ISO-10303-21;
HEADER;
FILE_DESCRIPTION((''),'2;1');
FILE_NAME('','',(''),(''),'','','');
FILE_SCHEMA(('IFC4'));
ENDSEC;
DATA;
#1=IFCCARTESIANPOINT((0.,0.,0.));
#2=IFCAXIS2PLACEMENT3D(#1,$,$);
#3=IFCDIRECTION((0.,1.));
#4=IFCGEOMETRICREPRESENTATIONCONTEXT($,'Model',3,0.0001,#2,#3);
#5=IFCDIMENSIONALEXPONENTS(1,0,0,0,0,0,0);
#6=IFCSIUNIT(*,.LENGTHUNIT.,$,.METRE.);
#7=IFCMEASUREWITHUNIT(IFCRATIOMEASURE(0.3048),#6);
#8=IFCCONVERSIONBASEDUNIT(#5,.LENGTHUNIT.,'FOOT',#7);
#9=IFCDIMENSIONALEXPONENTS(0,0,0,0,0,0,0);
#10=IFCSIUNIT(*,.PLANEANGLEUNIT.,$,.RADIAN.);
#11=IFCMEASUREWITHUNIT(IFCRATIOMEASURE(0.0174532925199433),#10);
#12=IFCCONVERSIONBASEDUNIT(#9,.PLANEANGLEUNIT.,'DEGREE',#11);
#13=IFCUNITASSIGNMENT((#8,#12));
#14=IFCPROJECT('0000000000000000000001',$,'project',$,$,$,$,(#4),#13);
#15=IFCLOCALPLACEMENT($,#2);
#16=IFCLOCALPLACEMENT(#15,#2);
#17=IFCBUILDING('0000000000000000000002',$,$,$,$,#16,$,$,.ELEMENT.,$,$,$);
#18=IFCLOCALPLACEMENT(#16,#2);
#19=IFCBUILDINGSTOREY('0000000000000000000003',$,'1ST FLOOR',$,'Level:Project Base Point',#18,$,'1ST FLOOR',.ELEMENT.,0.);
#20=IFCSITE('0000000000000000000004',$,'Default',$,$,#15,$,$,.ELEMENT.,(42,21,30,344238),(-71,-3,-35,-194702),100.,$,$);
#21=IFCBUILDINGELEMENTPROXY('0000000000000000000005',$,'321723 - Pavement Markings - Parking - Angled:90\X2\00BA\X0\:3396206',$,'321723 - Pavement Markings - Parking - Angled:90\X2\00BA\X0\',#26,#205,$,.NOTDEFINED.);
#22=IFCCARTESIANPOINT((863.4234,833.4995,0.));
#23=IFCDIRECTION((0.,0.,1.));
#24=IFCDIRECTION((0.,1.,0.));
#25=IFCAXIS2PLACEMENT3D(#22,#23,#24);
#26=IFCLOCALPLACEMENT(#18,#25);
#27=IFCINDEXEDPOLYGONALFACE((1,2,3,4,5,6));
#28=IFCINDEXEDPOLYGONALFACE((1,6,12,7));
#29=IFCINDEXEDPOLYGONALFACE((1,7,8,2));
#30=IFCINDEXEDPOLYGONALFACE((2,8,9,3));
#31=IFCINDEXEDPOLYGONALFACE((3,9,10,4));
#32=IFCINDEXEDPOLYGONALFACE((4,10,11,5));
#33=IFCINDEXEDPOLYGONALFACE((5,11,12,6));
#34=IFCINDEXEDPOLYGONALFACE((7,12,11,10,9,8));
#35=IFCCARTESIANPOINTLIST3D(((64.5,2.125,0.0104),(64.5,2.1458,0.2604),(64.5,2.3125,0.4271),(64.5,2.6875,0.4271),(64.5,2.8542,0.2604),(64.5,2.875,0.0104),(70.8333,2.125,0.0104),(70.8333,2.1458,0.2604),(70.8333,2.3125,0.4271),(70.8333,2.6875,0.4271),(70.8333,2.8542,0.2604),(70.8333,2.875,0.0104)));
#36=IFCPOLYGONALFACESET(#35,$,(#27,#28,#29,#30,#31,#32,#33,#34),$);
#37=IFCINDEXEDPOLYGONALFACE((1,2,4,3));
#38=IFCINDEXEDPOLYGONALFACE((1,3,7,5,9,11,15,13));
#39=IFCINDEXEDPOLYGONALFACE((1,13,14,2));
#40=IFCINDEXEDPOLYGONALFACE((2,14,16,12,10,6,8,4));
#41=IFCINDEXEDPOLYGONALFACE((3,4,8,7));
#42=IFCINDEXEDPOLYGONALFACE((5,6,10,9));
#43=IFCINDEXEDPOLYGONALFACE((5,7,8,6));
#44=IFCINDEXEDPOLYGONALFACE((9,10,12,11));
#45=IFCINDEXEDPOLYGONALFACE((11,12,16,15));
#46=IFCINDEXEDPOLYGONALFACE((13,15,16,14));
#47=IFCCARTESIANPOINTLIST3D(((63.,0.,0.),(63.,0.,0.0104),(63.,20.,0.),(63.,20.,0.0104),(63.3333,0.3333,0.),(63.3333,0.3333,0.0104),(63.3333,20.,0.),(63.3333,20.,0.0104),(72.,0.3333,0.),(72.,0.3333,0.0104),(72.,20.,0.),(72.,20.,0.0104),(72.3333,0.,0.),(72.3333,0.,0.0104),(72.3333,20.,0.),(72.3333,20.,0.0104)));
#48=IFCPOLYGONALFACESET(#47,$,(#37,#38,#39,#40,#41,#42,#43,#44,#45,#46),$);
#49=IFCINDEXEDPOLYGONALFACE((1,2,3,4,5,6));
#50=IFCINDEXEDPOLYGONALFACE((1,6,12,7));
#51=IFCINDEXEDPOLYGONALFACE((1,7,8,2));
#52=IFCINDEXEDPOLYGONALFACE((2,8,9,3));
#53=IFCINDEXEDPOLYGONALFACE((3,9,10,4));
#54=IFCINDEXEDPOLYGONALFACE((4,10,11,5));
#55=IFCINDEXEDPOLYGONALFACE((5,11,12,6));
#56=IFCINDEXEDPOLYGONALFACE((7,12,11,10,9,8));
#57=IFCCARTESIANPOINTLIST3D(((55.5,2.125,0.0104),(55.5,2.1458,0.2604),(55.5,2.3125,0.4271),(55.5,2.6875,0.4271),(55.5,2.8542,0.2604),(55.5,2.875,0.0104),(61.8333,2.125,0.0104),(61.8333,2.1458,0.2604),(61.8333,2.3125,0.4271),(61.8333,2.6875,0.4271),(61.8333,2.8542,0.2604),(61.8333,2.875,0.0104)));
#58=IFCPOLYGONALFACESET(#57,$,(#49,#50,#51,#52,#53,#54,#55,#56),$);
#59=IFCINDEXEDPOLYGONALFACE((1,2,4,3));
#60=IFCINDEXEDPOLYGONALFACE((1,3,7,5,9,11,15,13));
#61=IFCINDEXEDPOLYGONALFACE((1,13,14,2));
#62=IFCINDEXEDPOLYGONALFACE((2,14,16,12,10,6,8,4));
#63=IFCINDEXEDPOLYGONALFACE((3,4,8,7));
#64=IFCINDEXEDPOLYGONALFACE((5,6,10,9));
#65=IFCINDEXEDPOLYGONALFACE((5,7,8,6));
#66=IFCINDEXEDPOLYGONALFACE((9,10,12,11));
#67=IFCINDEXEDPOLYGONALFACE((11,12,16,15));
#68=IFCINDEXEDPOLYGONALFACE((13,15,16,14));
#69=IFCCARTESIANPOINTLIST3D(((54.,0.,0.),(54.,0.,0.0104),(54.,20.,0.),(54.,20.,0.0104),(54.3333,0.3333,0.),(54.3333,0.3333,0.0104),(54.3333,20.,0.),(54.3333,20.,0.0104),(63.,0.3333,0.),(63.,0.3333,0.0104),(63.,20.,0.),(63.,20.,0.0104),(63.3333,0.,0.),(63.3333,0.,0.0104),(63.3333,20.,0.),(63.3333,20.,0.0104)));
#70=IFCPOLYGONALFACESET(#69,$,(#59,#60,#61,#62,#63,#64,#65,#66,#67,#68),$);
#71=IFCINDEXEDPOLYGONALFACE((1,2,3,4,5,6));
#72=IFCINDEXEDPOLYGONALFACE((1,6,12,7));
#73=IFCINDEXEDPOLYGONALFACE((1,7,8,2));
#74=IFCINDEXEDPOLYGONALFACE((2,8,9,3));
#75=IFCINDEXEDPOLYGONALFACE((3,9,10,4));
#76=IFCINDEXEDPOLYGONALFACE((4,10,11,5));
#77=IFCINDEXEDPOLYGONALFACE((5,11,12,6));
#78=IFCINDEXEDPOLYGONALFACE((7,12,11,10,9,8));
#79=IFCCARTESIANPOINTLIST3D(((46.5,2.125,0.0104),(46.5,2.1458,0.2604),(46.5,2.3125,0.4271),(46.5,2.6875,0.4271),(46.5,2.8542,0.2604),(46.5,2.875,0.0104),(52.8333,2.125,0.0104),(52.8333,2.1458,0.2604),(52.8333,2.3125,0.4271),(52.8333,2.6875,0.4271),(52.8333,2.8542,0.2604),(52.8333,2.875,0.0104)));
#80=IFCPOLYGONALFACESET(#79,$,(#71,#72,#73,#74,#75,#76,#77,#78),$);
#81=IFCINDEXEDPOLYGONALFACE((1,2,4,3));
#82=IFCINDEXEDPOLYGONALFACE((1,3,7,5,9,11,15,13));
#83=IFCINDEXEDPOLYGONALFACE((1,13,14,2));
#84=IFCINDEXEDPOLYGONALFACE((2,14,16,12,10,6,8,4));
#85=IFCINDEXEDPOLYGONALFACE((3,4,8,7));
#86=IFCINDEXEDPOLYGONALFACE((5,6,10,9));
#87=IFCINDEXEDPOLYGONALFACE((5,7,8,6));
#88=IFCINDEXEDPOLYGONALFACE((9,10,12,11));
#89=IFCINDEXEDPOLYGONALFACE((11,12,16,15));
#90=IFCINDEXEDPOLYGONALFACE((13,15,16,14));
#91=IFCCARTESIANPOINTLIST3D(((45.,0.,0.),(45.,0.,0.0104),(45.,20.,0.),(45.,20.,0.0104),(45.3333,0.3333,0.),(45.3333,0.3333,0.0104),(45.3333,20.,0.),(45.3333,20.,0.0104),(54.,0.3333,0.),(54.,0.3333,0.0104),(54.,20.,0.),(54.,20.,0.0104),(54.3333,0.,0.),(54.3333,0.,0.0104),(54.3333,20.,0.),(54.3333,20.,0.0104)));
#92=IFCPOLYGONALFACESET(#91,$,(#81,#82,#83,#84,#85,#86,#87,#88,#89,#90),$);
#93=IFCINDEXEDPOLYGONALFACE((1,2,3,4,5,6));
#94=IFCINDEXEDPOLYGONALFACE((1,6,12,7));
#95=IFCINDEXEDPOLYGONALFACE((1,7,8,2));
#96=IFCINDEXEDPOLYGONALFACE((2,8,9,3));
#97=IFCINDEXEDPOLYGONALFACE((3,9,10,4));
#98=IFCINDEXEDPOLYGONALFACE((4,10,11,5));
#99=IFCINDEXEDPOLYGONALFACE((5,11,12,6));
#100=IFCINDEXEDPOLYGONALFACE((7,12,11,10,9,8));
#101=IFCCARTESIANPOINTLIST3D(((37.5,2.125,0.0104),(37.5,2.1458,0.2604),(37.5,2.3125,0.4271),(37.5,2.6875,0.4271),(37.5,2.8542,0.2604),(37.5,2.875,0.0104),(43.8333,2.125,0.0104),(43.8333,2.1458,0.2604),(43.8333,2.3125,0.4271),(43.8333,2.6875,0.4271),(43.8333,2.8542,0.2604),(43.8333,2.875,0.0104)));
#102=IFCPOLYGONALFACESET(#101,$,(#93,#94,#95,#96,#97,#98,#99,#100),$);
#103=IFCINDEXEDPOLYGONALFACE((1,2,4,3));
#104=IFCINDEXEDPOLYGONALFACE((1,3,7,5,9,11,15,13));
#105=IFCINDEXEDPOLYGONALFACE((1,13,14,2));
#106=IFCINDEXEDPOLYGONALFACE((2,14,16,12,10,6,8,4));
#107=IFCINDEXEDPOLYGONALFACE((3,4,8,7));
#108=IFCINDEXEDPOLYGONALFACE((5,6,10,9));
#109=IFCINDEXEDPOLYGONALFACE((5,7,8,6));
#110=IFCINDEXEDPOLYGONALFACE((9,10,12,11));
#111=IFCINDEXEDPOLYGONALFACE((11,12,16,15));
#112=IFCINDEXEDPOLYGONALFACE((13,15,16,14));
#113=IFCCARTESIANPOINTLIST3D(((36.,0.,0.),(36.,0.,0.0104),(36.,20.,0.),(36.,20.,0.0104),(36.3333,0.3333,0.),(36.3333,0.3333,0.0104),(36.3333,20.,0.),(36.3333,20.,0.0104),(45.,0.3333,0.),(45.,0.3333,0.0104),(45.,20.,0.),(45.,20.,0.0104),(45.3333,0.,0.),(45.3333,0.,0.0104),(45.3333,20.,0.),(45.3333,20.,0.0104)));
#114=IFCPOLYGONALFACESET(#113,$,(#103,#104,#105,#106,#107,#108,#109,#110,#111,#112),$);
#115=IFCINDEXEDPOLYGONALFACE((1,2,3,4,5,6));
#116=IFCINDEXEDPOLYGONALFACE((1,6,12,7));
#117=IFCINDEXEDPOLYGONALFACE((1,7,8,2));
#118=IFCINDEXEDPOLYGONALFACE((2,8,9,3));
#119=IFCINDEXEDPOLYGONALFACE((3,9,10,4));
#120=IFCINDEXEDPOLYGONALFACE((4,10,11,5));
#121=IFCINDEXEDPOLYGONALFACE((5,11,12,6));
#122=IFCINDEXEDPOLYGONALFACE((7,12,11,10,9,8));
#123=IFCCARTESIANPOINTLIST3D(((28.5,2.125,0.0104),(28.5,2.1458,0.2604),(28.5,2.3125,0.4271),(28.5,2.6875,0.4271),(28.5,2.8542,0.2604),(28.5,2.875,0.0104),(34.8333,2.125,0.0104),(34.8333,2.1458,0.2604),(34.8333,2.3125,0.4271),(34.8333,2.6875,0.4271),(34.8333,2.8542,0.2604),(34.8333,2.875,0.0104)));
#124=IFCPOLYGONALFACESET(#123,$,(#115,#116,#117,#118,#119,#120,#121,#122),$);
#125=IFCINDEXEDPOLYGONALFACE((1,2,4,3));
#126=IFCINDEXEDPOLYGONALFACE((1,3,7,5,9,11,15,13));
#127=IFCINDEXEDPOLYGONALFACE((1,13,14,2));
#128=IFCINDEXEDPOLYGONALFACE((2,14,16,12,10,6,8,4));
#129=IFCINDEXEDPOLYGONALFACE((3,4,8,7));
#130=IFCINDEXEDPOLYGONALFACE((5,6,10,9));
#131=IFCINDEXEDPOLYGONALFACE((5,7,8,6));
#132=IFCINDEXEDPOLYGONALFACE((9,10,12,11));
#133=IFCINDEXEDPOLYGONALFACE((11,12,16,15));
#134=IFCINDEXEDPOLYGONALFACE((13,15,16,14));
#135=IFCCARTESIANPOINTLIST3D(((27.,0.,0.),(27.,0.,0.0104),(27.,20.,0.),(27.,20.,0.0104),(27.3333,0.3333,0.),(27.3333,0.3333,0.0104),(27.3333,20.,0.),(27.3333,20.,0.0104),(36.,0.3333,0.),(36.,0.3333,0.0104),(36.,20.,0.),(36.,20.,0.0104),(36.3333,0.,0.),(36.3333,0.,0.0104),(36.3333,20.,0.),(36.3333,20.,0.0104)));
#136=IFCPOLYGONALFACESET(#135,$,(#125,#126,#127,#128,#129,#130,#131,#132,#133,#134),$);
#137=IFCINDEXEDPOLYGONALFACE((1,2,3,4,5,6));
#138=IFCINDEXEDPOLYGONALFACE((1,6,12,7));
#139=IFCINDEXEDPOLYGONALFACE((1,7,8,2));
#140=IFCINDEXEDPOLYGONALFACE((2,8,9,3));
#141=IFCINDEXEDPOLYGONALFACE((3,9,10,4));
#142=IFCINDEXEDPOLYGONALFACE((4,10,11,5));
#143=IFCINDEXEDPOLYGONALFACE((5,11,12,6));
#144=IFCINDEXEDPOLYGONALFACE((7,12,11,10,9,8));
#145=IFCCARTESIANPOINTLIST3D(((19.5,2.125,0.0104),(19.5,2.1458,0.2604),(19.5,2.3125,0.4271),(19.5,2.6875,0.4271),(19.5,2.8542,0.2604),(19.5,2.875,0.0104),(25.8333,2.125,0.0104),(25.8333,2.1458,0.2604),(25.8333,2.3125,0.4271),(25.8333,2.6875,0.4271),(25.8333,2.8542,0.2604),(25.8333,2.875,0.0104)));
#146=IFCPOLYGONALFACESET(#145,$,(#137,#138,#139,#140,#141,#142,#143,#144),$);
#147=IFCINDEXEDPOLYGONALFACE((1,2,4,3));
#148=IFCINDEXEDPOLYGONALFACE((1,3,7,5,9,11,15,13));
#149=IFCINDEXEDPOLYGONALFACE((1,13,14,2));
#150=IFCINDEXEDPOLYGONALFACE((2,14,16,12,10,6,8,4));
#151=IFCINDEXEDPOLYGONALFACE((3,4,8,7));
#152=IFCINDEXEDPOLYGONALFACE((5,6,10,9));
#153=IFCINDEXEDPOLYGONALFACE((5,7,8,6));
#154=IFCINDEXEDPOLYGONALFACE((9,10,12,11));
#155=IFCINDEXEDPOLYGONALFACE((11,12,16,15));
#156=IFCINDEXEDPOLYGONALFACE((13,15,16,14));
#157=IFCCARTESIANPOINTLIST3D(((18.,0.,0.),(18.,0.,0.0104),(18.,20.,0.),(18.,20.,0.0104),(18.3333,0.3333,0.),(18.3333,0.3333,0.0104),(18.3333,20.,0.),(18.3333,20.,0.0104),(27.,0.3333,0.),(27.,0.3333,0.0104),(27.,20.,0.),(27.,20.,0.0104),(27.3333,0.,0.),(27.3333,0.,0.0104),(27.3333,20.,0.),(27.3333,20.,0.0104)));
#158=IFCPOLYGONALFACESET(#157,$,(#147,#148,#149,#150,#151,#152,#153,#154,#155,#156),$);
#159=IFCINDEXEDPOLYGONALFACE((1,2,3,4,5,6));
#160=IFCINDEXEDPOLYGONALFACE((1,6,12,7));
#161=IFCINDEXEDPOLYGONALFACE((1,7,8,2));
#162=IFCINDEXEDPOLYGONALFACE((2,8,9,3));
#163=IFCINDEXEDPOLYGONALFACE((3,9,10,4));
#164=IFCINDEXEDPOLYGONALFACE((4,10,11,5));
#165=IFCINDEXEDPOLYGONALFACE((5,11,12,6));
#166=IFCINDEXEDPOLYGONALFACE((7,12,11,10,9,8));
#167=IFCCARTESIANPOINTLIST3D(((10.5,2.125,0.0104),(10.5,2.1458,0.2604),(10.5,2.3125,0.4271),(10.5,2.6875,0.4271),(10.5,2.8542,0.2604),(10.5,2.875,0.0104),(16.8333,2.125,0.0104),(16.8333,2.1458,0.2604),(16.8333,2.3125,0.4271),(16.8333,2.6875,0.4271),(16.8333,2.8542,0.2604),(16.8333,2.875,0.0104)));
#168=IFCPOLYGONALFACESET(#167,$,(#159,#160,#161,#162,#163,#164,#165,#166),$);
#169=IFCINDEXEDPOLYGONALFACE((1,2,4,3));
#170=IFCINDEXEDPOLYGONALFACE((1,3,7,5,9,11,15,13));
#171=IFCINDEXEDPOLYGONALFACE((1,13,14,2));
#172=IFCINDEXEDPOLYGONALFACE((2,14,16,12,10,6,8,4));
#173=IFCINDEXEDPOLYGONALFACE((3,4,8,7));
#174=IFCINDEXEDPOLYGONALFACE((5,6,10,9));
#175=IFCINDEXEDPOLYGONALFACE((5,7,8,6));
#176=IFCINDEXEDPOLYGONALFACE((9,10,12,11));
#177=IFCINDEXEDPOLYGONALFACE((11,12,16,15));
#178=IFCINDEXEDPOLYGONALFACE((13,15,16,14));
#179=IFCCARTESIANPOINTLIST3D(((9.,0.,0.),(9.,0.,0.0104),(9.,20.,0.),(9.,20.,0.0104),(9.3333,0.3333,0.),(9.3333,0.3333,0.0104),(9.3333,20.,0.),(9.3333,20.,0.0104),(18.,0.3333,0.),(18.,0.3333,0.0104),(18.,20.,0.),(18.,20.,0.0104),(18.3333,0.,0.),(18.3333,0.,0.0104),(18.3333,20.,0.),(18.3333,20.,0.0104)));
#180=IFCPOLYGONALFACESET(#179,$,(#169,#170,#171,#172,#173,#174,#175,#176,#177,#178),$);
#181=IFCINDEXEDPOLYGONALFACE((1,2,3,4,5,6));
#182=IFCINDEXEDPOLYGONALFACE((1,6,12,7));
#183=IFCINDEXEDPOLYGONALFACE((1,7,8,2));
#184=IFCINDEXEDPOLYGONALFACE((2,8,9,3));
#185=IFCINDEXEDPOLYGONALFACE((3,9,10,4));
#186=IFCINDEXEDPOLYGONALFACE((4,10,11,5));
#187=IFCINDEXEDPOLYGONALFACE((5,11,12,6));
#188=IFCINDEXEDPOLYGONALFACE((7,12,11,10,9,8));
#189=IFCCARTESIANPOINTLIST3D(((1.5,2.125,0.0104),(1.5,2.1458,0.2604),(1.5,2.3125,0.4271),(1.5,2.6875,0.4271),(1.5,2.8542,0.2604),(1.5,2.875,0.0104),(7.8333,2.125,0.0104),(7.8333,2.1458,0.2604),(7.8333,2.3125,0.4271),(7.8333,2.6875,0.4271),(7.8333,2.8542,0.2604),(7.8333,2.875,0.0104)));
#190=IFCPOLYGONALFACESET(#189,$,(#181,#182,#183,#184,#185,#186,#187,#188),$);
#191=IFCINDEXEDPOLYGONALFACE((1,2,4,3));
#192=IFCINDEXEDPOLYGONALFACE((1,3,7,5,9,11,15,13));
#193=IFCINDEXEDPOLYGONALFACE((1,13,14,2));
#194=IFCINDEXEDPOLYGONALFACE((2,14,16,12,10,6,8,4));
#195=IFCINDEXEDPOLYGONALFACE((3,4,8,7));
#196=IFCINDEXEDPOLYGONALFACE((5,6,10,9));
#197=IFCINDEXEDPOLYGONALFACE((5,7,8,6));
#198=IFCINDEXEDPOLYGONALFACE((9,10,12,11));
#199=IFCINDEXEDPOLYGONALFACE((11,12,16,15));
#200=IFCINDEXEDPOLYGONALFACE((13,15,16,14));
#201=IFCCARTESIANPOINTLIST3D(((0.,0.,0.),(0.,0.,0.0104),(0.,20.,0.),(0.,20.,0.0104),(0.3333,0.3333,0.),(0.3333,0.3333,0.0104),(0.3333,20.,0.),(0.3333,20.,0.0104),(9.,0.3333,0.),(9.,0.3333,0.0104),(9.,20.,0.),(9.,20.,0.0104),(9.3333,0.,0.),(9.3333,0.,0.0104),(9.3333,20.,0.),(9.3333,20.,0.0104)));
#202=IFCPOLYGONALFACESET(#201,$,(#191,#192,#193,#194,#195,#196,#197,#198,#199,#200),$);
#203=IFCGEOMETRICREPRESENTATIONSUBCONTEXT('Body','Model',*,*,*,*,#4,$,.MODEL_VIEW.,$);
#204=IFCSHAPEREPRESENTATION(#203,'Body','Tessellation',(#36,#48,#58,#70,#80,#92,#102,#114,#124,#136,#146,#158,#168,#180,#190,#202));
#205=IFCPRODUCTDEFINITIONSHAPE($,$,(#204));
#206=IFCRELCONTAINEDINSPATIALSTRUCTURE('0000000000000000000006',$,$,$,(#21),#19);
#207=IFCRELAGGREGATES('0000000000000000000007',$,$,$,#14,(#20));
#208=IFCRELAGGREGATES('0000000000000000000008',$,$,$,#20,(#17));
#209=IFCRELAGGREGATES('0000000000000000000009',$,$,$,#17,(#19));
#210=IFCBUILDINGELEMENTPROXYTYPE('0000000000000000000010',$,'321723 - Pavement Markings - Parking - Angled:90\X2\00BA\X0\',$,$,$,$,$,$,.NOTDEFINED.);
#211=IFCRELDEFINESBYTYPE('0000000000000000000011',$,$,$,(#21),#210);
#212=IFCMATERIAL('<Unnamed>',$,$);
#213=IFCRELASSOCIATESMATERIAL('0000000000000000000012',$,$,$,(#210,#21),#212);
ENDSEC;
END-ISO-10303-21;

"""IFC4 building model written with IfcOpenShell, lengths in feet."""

from ifc_helpers import new_model, entity, si_unit, converted_unit, direction, frame, origin, place, context, subcontext, project, spatial, polyline, outline, extrude, source, transform, mapped, material, type_object, type_shapes, element, save


model = new_model("IFC4")

# Units and contexts
model_context = context("Model", 3, precision=0.0001, world=origin(), true_north=direction((0.0, 1.0)))
body_context = subcontext(model_context, "Body", "Model", "MODEL_VIEW")
ifc_project = project(units=[converted_unit("LENGTHUNIT", "FOOT", entity("IfcRatioMeasure", 0.3048), si_unit("LENGTHUNIT", "METRE"), dimensions=[1, 0, 0, 0, 0, 0, 0]), converted_unit("PLANEANGLEUNIT", "DEGREE", entity("IfcRatioMeasure", 0.0174532925199433), si_unit("PLANEANGLEUNIT", "RADIAN"), dimensions=[0, 0, 0, 0, 0, 0, 0])], contexts=[model_context])

# Site, building, storey
site_placement = place(None, origin())
site = spatial("IfcSite", under=ifc_project, at=site_placement, Name="Default", CompositionType="ELEMENT", RefLatitude=(42, 21, 30, 344238), RefLongitude=(-71, -3, -35, -194702), RefElevation=100.0)
building_placement = place(site_placement, origin())
building = spatial("IfcBuilding", under=site, at=building_placement, CompositionType="ELEMENT")
storey_placement = place(building_placement, origin())
storey = spatial("IfcBuildingStorey", under=building, at=storey_placement, Name="1ST FLOOR", ObjectType="Level:Project Base Point", LongName="1ST FLOOR", CompositionType="ELEMENT", Elevation=0.0)

# Building element proxy
ifc_material_1 = material(Name="<Unnamed>")
building_element_proxy_type_1 = type_object("IfcBuildingElementProxyType", Name="321723 - Pavement Markings - Parking - Angled:90º", PredefinedType="NOTDEFINED", material=ifc_material_1)
shared_shape_1 = source(origin(), body_context, "Body", "SweptSolid", [
    extrude(outline(polyline([(-0.375, -0.2222), (0.375, -0.2222), (0.3542, 0.0278), (0.1875, 0.1944), (-0.1875, 0.1944), (-0.3542, 0.0278), (-0.375, -0.2222)])), frame((64.5, 2.5, 0.2326), z_axis=(1.0, 0.0, 0.0), x_axis=(0.0, 1.0, 0.0)), (0.0, 0.0, 1.0), 6.3333),
    extrude(outline(polyline([(-4.6667, -10.0833), (4.6667, -10.0833), (4.6667, 9.9167), (4.3333, 9.9167), (4.3333, -9.75), (-4.3333, -9.75), (-4.3333, 9.9167), (-4.6667, 9.9167), (-4.6667, -10.0833)])), frame((67.6667, 10.0833, 0.0)), (0.0, 0.0, 1.0), 0.0104),
    extrude(outline(polyline([(-0.375, -0.2222), (0.375, -0.2222), (0.3542, 0.0278), (0.1875, 0.1944), (-0.1875, 0.1944), (-0.3542, 0.0278), (-0.375, -0.2222)])), frame((55.5, 2.5, 0.2326), z_axis=(1.0, 0.0, 0.0), x_axis=(0.0, 1.0, 0.0)), (0.0, 0.0, 1.0), 6.3333),
    extrude(outline(polyline([(-4.6667, -10.0833), (4.6667, -10.0833), (4.6667, 9.9167), (4.3333, 9.9167), (4.3333, -9.75), (-4.3333, -9.75), (-4.3333, 9.9167), (-4.6667, 9.9167), (-4.6667, -10.0833)])), frame((58.6667, 10.0833, 0.0)), (0.0, 0.0, 1.0), 0.0104),
    extrude(outline(polyline([(-0.375, -0.2222), (0.375, -0.2222), (0.3542, 0.0278), (0.1875, 0.1944), (-0.1875, 0.1944), (-0.3542, 0.0278), (-0.375, -0.2222)])), frame((46.5, 2.5, 0.2326), z_axis=(1.0, 0.0, 0.0), x_axis=(0.0, 1.0, 0.0)), (0.0, 0.0, 1.0), 6.3333),
    extrude(outline(polyline([(-4.6667, -10.0833), (4.6667, -10.0833), (4.6667, 9.9167), (4.3333, 9.9167), (4.3333, -9.75), (-4.3333, -9.75), (-4.3333, 9.9167), (-4.6667, 9.9167), (-4.6667, -10.0833)])), frame((49.6667, 10.0833, 0.0)), (0.0, 0.0, 1.0), 0.0104),
    extrude(outline(polyline([(-0.375, -0.2222), (0.375, -0.2222), (0.3542, 0.0278), (0.1875, 0.1944), (-0.1875, 0.1944), (-0.3542, 0.0278), (-0.375, -0.2222)])), frame((37.5, 2.5, 0.2326), z_axis=(1.0, 0.0, 0.0), x_axis=(0.0, 1.0, 0.0)), (0.0, 0.0, 1.0), 6.3333),
    extrude(outline(polyline([(-4.6667, -10.0833), (4.6667, -10.0833), (4.6667, 9.9167), (4.3333, 9.9167), (4.3333, -9.75), (-4.3333, -9.75), (-4.3333, 9.9167), (-4.6667, 9.9167), (-4.6667, -10.0833)])), frame((40.6667, 10.0833, 0.0)), (0.0, 0.0, 1.0), 0.0104),
    extrude(outline(polyline([(-0.375, -0.2222), (0.375, -0.2222), (0.3542, 0.0278), (0.1875, 0.1944), (-0.1875, 0.1944), (-0.3542, 0.0278), (-0.375, -0.2222)])), frame((28.5, 2.5, 0.2326), z_axis=(1.0, 0.0, 0.0), x_axis=(0.0, 1.0, 0.0)), (0.0, 0.0, 1.0), 6.3333),
    extrude(outline(polyline([(-4.6667, -10.0833), (4.6667, -10.0833), (4.6667, 9.9167), (4.3333, 9.9167), (4.3333, -9.75), (-4.3333, -9.75), (-4.3333, 9.9167), (-4.6667, 9.9167), (-4.6667, -10.0833)])), frame((31.6667, 10.0833, 0.0)), (0.0, 0.0, 1.0), 0.0104),
    extrude(outline(polyline([(-0.375, -0.2222), (0.375, -0.2222), (0.3542, 0.0278), (0.1875, 0.1944), (-0.1875, 0.1944), (-0.3542, 0.0278), (-0.375, -0.2222)])), frame((19.5, 2.5, 0.2326), z_axis=(1.0, 0.0, 0.0), x_axis=(0.0, 1.0, 0.0)), (0.0, 0.0, 1.0), 6.3333),
    extrude(outline(polyline([(-4.6667, -10.0833), (4.6667, -10.0833), (4.6667, 9.9167), (4.3333, 9.9167), (4.3333, -9.75), (-4.3333, -9.75), (-4.3333, 9.9167), (-4.6667, 9.9167), (-4.6667, -10.0833)])), frame((22.6667, 10.0833, 0.0)), (0.0, 0.0, 1.0), 0.0104),
    extrude(outline(polyline([(-0.375, -0.2222), (0.375, -0.2222), (0.3542, 0.0278), (0.1875, 0.1944), (-0.1875, 0.1944), (-0.3542, 0.0278), (-0.375, -0.2222)])), frame((10.5, 2.5, 0.2326), z_axis=(1.0, 0.0, 0.0), x_axis=(0.0, 1.0, 0.0)), (0.0, 0.0, 1.0), 6.3333),
    extrude(outline(polyline([(-4.6667, -10.0833), (4.6667, -10.0833), (4.6667, 9.9167), (4.3333, 9.9167), (4.3333, -9.75), (-4.3333, -9.75), (-4.3333, 9.9167), (-4.6667, 9.9167), (-4.6667, -10.0833)])), frame((13.6667, 10.0833, 0.0)), (0.0, 0.0, 1.0), 0.0104),
    extrude(outline(polyline([(-0.375, -0.2222), (0.375, -0.2222), (0.3542, 0.0278), (0.1875, 0.1944), (-0.1875, 0.1944), (-0.3542, 0.0278), (-0.375, -0.2222)])), frame((1.5, 2.5, 0.2326), z_axis=(1.0, 0.0, 0.0), x_axis=(0.0, 1.0, 0.0)), (0.0, 0.0, 1.0), 6.3333),
    extrude(outline(polyline([(-4.6667, -10.0833), (4.6667, -10.0833), (4.6667, 9.9167), (4.3333, 9.9167), (4.3333, -9.75), (-4.3333, -9.75), (-4.3333, 9.9167), (-4.6667, 9.9167), (-4.6667, -10.0833)])), frame((4.6667, 10.0833, 0.0)), (0.0, 0.0, 1.0), 0.0104),
])
type_shapes(building_element_proxy_type_1, [shared_shape_1])
proxy_1_placement = place(storey_placement, frame((863.4234, 833.4995, 0.0), z_axis=(0.0, 0.0, 1.0), x_axis=(0.0, 1.0, 0.0)))
element("IfcBuildingElementProxy", 1, at=proxy_1_placement, inside=storey, type_object=building_element_proxy_type_1, material=ifc_material_1, Name="321723 - Pavement Markings - Parking - Angled:90º:3396206", ObjectType="321723 - Pavement Markings - Parking - Angled:90º", PredefinedType="NOTDEFINED", context=body_context, shape_type="MappedRepresentation", body=[
    mapped(shared_shape_1, transform((0.0, 0.0, 0.0), scale=1.0)),
])

save(model, "model.ifc")
